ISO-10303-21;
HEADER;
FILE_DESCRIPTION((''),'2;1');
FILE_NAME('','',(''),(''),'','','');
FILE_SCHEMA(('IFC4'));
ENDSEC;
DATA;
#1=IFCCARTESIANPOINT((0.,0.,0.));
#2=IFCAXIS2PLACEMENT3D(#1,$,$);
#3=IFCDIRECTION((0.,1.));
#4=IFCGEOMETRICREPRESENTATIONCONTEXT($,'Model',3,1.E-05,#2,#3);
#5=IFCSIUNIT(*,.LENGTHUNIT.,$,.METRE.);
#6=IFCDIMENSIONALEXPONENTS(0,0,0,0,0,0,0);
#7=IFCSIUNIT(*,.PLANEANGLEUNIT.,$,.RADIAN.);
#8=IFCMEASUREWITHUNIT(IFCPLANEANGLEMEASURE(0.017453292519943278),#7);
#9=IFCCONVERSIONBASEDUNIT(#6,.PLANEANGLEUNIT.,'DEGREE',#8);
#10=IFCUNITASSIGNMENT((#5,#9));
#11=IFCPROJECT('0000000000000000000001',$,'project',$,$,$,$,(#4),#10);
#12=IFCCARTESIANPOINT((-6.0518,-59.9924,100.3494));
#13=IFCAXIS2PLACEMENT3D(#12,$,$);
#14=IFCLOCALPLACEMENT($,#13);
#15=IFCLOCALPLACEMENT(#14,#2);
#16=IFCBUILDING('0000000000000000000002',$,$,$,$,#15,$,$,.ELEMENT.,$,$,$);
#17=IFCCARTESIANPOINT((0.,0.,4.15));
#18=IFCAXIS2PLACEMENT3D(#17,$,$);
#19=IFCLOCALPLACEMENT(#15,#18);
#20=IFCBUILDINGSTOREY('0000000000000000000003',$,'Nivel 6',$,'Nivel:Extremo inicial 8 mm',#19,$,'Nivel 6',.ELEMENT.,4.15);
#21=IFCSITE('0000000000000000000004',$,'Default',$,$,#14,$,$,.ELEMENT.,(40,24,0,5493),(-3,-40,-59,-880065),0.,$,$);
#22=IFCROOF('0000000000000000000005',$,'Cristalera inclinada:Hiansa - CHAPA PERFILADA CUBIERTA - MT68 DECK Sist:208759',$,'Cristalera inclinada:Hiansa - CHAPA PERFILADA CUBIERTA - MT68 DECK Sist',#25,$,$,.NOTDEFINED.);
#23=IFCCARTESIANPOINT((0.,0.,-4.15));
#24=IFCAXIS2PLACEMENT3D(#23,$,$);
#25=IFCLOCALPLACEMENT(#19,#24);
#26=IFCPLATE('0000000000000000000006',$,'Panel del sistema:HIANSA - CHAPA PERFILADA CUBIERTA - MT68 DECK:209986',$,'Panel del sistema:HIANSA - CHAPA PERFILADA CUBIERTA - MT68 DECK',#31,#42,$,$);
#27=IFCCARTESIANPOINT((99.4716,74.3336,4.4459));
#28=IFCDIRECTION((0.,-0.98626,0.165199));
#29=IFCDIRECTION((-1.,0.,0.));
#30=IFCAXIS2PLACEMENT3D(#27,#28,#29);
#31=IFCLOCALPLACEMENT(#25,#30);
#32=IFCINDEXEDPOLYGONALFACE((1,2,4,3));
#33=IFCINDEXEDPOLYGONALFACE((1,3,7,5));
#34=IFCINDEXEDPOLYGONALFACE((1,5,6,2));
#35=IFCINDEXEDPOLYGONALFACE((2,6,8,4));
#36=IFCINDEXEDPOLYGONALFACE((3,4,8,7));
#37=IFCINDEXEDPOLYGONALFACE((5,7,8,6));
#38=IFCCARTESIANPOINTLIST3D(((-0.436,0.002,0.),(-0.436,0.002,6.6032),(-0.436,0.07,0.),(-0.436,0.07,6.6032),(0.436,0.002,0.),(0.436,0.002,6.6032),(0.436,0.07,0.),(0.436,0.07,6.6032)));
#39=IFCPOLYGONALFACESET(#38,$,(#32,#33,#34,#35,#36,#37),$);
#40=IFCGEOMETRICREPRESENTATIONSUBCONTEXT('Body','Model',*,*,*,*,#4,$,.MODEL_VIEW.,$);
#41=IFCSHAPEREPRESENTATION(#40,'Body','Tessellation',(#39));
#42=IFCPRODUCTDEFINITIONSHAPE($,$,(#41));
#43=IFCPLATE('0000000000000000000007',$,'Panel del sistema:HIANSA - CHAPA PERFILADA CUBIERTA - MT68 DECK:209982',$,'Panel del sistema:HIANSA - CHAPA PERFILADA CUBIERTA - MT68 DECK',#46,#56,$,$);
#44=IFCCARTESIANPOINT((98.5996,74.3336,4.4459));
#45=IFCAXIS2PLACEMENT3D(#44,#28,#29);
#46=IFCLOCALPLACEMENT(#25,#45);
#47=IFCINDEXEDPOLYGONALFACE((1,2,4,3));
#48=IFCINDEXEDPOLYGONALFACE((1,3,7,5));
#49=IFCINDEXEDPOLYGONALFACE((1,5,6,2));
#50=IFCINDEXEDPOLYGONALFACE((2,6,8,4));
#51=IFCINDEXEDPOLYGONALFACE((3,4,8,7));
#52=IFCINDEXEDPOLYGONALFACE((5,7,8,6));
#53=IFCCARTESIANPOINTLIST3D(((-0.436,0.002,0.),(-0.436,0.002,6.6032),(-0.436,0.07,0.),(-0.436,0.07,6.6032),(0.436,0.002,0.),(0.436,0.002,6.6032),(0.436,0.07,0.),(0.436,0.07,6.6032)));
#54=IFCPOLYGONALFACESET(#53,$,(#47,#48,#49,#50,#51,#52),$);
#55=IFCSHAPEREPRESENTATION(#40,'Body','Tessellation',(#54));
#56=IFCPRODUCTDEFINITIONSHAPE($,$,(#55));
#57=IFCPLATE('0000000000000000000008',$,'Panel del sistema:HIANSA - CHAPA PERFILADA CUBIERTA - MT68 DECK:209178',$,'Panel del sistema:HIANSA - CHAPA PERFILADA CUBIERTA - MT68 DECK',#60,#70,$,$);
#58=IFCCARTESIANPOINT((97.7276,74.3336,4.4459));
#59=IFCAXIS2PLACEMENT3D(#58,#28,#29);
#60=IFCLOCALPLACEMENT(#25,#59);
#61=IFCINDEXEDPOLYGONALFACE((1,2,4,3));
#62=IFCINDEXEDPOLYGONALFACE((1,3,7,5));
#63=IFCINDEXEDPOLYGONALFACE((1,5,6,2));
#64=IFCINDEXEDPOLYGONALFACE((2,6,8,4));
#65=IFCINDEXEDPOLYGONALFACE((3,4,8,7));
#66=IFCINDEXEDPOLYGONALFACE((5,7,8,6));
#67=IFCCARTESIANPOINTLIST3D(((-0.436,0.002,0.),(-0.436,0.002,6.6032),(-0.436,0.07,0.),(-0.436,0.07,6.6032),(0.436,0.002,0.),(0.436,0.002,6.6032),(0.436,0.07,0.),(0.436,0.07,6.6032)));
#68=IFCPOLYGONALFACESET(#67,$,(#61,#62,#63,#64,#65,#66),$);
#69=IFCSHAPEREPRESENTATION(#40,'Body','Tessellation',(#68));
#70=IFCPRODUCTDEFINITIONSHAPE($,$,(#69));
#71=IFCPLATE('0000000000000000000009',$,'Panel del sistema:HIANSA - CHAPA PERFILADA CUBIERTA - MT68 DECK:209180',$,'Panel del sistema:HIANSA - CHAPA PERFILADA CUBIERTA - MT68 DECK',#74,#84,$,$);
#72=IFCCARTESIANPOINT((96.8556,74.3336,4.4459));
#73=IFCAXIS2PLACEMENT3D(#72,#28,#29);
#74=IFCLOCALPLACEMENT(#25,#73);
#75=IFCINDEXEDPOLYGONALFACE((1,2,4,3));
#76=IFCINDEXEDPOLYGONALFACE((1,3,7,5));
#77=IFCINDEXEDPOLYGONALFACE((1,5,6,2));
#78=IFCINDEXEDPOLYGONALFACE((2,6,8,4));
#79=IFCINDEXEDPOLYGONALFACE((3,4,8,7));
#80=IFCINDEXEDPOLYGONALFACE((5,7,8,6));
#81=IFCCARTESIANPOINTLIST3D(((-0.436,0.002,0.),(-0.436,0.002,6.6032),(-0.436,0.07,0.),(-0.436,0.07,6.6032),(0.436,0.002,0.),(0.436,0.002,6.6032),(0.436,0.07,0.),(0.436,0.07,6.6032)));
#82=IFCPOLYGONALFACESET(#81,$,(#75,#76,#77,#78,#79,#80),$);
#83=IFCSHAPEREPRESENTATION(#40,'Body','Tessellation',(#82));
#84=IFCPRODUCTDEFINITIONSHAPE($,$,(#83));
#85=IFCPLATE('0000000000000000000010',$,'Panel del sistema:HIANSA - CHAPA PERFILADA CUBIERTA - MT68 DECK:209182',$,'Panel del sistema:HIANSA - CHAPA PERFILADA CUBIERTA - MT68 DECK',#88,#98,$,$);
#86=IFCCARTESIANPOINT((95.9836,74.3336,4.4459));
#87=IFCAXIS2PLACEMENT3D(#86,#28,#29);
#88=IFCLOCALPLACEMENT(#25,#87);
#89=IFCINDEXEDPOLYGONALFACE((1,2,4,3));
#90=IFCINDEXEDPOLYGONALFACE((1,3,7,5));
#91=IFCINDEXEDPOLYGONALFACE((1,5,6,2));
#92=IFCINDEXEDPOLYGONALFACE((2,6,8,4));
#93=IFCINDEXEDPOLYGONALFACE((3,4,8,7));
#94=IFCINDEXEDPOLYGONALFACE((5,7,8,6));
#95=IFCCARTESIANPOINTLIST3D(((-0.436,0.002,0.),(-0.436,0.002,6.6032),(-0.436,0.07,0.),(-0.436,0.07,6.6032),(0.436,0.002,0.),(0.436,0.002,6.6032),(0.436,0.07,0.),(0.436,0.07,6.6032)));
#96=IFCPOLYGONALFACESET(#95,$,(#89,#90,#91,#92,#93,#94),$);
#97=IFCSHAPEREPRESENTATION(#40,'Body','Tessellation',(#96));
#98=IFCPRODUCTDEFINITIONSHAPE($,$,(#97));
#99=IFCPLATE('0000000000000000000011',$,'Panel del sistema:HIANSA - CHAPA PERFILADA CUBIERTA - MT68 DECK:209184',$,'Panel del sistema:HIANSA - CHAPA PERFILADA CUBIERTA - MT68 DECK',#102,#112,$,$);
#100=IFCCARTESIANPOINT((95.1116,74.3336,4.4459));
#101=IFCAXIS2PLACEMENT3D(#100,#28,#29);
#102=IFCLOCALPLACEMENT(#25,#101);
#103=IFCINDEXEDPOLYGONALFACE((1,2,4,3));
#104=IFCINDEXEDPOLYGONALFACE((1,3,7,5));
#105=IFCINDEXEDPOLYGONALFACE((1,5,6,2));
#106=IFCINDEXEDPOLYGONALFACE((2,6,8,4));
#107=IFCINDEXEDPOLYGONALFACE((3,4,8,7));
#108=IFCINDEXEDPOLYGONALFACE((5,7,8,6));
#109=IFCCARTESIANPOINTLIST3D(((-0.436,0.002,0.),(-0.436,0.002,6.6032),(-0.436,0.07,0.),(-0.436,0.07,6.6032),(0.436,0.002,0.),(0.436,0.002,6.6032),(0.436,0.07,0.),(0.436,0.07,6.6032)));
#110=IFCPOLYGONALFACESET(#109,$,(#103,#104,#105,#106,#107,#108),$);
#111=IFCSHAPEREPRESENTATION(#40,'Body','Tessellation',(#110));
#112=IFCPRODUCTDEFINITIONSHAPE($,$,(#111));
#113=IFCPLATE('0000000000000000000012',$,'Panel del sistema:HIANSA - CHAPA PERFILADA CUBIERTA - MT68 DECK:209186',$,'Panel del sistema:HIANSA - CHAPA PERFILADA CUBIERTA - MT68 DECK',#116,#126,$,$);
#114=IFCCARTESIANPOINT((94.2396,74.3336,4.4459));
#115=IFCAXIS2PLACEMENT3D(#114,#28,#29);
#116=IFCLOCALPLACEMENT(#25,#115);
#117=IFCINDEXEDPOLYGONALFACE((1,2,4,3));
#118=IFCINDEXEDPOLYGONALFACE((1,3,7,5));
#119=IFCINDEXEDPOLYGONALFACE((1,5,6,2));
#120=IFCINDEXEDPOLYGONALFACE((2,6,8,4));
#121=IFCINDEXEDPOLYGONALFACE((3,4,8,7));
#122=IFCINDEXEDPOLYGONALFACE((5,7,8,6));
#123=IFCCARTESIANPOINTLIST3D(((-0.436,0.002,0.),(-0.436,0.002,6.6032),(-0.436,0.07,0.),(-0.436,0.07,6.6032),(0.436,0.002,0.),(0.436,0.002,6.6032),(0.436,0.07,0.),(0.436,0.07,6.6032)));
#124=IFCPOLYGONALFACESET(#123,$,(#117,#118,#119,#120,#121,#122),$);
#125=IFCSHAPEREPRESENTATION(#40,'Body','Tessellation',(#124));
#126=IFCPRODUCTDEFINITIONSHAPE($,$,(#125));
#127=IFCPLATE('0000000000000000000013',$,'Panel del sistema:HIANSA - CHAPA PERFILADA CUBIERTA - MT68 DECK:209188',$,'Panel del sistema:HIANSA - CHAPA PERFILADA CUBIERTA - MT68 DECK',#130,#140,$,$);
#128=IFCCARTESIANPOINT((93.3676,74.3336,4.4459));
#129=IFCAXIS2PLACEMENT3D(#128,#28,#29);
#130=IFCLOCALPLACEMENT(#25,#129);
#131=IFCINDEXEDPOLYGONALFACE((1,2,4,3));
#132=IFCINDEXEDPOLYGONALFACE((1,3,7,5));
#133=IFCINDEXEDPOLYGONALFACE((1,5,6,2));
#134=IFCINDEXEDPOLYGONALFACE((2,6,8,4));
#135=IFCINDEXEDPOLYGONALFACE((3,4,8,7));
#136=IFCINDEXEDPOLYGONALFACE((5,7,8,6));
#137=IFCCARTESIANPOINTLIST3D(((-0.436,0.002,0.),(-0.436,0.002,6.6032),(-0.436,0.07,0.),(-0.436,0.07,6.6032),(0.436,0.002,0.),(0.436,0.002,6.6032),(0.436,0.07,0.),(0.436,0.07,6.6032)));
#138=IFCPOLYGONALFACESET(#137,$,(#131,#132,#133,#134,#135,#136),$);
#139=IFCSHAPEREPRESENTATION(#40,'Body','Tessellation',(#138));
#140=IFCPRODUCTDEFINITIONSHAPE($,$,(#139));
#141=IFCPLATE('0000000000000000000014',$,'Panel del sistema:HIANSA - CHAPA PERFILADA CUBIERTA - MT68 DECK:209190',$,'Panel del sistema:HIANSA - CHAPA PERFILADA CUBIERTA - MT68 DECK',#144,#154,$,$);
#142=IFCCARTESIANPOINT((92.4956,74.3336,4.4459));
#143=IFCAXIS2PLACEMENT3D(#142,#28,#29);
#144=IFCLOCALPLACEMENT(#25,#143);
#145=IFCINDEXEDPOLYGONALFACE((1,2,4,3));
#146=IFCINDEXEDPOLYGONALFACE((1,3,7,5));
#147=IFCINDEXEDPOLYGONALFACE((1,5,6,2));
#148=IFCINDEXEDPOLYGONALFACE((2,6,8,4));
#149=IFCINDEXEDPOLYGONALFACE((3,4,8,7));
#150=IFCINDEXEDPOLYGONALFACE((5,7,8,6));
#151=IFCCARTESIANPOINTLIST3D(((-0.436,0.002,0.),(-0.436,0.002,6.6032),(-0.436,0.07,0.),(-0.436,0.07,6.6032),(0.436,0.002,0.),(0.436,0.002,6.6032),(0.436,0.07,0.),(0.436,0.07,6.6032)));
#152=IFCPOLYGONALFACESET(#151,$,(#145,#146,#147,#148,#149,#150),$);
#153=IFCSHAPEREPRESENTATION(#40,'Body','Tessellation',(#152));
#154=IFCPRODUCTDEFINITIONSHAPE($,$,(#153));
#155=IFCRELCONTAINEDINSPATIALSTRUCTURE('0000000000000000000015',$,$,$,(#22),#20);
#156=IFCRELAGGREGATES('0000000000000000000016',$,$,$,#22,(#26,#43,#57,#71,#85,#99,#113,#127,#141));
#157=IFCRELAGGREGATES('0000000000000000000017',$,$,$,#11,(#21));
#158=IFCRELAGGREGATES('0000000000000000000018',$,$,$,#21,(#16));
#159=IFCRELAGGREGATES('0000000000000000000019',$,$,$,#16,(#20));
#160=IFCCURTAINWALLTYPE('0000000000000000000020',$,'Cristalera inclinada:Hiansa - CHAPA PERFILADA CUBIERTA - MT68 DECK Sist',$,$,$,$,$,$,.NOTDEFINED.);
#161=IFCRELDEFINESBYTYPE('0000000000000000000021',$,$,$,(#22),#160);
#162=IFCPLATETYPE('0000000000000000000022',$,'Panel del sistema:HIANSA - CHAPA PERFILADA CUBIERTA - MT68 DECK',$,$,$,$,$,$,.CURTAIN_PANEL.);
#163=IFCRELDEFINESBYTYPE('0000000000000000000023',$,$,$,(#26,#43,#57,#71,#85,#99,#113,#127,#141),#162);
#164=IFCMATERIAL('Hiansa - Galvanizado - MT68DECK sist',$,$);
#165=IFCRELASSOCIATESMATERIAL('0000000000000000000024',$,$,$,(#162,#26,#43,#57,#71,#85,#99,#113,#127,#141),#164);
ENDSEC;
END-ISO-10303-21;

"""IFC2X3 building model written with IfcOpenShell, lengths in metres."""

from ifc_helpers import new_model, entity, si_unit, converted_unit, direction, frame, origin, origin_2d_with_axis, place, context, subcontext, project, spatial, rectangle, extrude, source, transform, mapped, material, type_object, type_shapes, element, aggregate, save


model = new_model("IFC2X3")

# Units and contexts
model_context = context("Model", 3, precision=1e-05, world=origin(), true_north=direction((0.0, 1.0)))
body_context = subcontext(model_context, "Body", "Model", "MODEL_VIEW")
ifc_project = project(units=[si_unit("LENGTHUNIT", "METRE"), converted_unit("PLANEANGLEUNIT", "DEGREE", entity("IfcPlaneAngleMeasure", 0.017453292519943278), si_unit("PLANEANGLEUNIT", "RADIAN"), dimensions=[0, 0, 0, 0, 0, 0, 0])], contexts=[model_context])

# Site, building, storey
site_placement = place(None, frame((-6.0518, -59.9924, 100.3494)))
site = spatial("IfcSite", under=ifc_project, at=site_placement, Name="Default", CompositionType="ELEMENT", RefLatitude=(40, 24, 0, 5493), RefLongitude=(-3, -40, -59, -880065), RefElevation=0.0)
building_placement = place(site_placement, origin())
building = spatial("IfcBuilding", under=site, at=building_placement, CompositionType="ELEMENT")
storey_placement = place(building_placement, frame((0.0, 0.0, 4.15)))
storey = spatial("IfcBuildingStorey", under=building, at=storey_placement, Name="Nivel 6", ObjectType="Nivel:Extremo inicial 8 mm", LongName="Nivel 6", CompositionType="ELEMENT", Elevation=4.15)

# Roof, plates
curtain_wall_type = type_object("IfcCurtainWallType", Name="Cristalera inclinada:Hiansa - CHAPA PERFILADA CUBIERTA - MT68 DECK Sist", PredefinedType="NOTDEFINED")
roof_placement = place(storey_placement, frame((0.0, 0.0, -4.15)))
roof = element("IfcRoof", 1, at=roof_placement, inside=storey, type_object=curtain_wall_type, Name="Cristalera inclinada:Hiansa - CHAPA PERFILADA CUBIERTA - MT68 DECK Sist:208759", ObjectType="Cristalera inclinada:Hiansa - CHAPA PERFILADA CUBIERTA - MT68 DECK Sist", ShapeType="NOTDEFINED")
ifc_material_1 = material(Name="Hiansa - Galvanizado - MT68DECK sist")
plate_type_1 = type_object("IfcPlateType", Name="Panel del sistema:HIANSA - CHAPA PERFILADA CUBIERTA - MT68 DECK", PredefinedType="CURTAIN_PANEL", material=ifc_material_1)
shared_shape_1 = source(origin(), body_context, "Body", "SweptSolid", [
    extrude(rectangle(XDim=0.068, YDim=0.872, at=origin_2d_with_axis()), frame((0.0, 0.036, 0.0), z_axis=(0.0, 0.0, 1.0), x_axis=(0.0, 1.0, 0.0)), (0.0, 0.0, 1.0), 6.6032),
])
type_shapes(plate_type_1, [shared_shape_1])
plate_1_placement = place(roof_placement, frame((99.4716, 74.3336, 4.4459), z_axis=(0.0, -0.98626, 0.165199), x_axis=(-1.0, 0.0, 0.0)))
plate_1 = element("IfcPlate", 2, at=plate_1_placement, type_object=plate_type_1, material=ifc_material_1, Name="Panel del sistema:HIANSA - CHAPA PERFILADA CUBIERTA - MT68 DECK:209986", ObjectType="Panel del sistema:HIANSA - CHAPA PERFILADA CUBIERTA - MT68 DECK", context=body_context, shape_type="MappedRepresentation", body=[
    mapped(shared_shape_1, transform((0.0, 0.0, 0.0), scale=1.0)),
])
plate_2_placement = place(roof_placement, frame((98.5996, 74.3336, 4.4459), z_axis=(0.0, -0.98626, 0.165199), x_axis=(-1.0, 0.0, 0.0)))
plate_2 = element("IfcPlate", 3, at=plate_2_placement, type_object=plate_type_1, material=ifc_material_1, Name="Panel del sistema:HIANSA - CHAPA PERFILADA CUBIERTA - MT68 DECK:209982", ObjectType="Panel del sistema:HIANSA - CHAPA PERFILADA CUBIERTA - MT68 DECK", context=body_context, shape_type="MappedRepresentation", body=[
    mapped(shared_shape_1, transform((0.0, 0.0, 0.0), scale=1.0)),
])
plate_3_placement = place(roof_placement, frame((97.7276, 74.3336, 4.4459), z_axis=(0.0, -0.98626, 0.165199), x_axis=(-1.0, 0.0, 0.0)))
plate_3 = element("IfcPlate", 4, at=plate_3_placement, type_object=plate_type_1, material=ifc_material_1, Name="Panel del sistema:HIANSA - CHAPA PERFILADA CUBIERTA - MT68 DECK:209178", ObjectType="Panel del sistema:HIANSA - CHAPA PERFILADA CUBIERTA - MT68 DECK", context=body_context, shape_type="MappedRepresentation", body=[
    mapped(shared_shape_1, transform((0.0, 0.0, 0.0), scale=1.0)),
])
plate_4_placement = place(roof_placement, frame((96.8556, 74.3336, 4.4459), z_axis=(0.0, -0.98626, 0.165199), x_axis=(-1.0, 0.0, 0.0)))
plate_4 = element("IfcPlate", 5, at=plate_4_placement, type_object=plate_type_1, material=ifc_material_1, Name="Panel del sistema:HIANSA - CHAPA PERFILADA CUBIERTA - MT68 DECK:209180", ObjectType="Panel del sistema:HIANSA - CHAPA PERFILADA CUBIERTA - MT68 DECK", context=body_context, shape_type="MappedRepresentation", body=[
    mapped(shared_shape_1, transform((0.0, 0.0, 0.0), scale=1.0)),
])
plate_5_placement = place(roof_placement, frame((95.9836, 74.3336, 4.4459), z_axis=(0.0, -0.98626, 0.165199), x_axis=(-1.0, 0.0, 0.0)))
plate_5 = element("IfcPlate", 6, at=plate_5_placement, type_object=plate_type_1, material=ifc_material_1, Name="Panel del sistema:HIANSA - CHAPA PERFILADA CUBIERTA - MT68 DECK:209182", ObjectType="Panel del sistema:HIANSA - CHAPA PERFILADA CUBIERTA - MT68 DECK", context=body_context, shape_type="MappedRepresentation", body=[
    mapped(shared_shape_1, transform((0.0, 0.0, 0.0), scale=1.0)),
])
plate_6_placement = place(roof_placement, frame((95.1116, 74.3336, 4.4459), z_axis=(0.0, -0.98626, 0.165199), x_axis=(-1.0, 0.0, 0.0)))
plate_6 = element("IfcPlate", 7, at=plate_6_placement, type_object=plate_type_1, material=ifc_material_1, Name="Panel del sistema:HIANSA - CHAPA PERFILADA CUBIERTA - MT68 DECK:209184", ObjectType="Panel del sistema:HIANSA - CHAPA PERFILADA CUBIERTA - MT68 DECK", context=body_context, shape_type="MappedRepresentation", body=[
    mapped(shared_shape_1, transform((0.0, 0.0, 0.0), scale=1.0)),
])
plate_7_placement = place(roof_placement, frame((94.2396, 74.3336, 4.4459), z_axis=(0.0, -0.98626, 0.165199), x_axis=(-1.0, 0.0, 0.0)))
plate_7 = element("IfcPlate", 8, at=plate_7_placement, type_object=plate_type_1, material=ifc_material_1, Name="Panel del sistema:HIANSA - CHAPA PERFILADA CUBIERTA - MT68 DECK:209186", ObjectType="Panel del sistema:HIANSA - CHAPA PERFILADA CUBIERTA - MT68 DECK", context=body_context, shape_type="MappedRepresentation", body=[
    mapped(shared_shape_1, transform((0.0, 0.0, 0.0), scale=1.0)),
])
plate_8_placement = place(roof_placement, frame((93.3676, 74.3336, 4.4459), z_axis=(0.0, -0.98626, 0.165199), x_axis=(-1.0, 0.0, 0.0)))
plate_8 = element("IfcPlate", 9, at=plate_8_placement, type_object=plate_type_1, material=ifc_material_1, Name="Panel del sistema:HIANSA - CHAPA PERFILADA CUBIERTA - MT68 DECK:209188", ObjectType="Panel del sistema:HIANSA - CHAPA PERFILADA CUBIERTA - MT68 DECK", context=body_context, shape_type="MappedRepresentation", body=[
    mapped(shared_shape_1, transform((0.0, 0.0, 0.0), scale=1.0)),
])
plate_9_placement = place(roof_placement, frame((92.4956, 74.3336, 4.4459), z_axis=(0.0, -0.98626, 0.165199), x_axis=(-1.0, 0.0, 0.0)))
plate_9 = element("IfcPlate", 10, at=plate_9_placement, type_object=plate_type_1, material=ifc_material_1, Name="Panel del sistema:HIANSA - CHAPA PERFILADA CUBIERTA - MT68 DECK:209190", ObjectType="Panel del sistema:HIANSA - CHAPA PERFILADA CUBIERTA - MT68 DECK", context=body_context, shape_type="MappedRepresentation", body=[
    mapped(shared_shape_1, transform((0.0, 0.0, 0.0), scale=1.0)),
])
aggregate(roof, [plate_1, plate_2, plate_3, plate_4, plate_5, plate_6, plate_7, plate_8, plate_9])

save(model, "model.ifc")
